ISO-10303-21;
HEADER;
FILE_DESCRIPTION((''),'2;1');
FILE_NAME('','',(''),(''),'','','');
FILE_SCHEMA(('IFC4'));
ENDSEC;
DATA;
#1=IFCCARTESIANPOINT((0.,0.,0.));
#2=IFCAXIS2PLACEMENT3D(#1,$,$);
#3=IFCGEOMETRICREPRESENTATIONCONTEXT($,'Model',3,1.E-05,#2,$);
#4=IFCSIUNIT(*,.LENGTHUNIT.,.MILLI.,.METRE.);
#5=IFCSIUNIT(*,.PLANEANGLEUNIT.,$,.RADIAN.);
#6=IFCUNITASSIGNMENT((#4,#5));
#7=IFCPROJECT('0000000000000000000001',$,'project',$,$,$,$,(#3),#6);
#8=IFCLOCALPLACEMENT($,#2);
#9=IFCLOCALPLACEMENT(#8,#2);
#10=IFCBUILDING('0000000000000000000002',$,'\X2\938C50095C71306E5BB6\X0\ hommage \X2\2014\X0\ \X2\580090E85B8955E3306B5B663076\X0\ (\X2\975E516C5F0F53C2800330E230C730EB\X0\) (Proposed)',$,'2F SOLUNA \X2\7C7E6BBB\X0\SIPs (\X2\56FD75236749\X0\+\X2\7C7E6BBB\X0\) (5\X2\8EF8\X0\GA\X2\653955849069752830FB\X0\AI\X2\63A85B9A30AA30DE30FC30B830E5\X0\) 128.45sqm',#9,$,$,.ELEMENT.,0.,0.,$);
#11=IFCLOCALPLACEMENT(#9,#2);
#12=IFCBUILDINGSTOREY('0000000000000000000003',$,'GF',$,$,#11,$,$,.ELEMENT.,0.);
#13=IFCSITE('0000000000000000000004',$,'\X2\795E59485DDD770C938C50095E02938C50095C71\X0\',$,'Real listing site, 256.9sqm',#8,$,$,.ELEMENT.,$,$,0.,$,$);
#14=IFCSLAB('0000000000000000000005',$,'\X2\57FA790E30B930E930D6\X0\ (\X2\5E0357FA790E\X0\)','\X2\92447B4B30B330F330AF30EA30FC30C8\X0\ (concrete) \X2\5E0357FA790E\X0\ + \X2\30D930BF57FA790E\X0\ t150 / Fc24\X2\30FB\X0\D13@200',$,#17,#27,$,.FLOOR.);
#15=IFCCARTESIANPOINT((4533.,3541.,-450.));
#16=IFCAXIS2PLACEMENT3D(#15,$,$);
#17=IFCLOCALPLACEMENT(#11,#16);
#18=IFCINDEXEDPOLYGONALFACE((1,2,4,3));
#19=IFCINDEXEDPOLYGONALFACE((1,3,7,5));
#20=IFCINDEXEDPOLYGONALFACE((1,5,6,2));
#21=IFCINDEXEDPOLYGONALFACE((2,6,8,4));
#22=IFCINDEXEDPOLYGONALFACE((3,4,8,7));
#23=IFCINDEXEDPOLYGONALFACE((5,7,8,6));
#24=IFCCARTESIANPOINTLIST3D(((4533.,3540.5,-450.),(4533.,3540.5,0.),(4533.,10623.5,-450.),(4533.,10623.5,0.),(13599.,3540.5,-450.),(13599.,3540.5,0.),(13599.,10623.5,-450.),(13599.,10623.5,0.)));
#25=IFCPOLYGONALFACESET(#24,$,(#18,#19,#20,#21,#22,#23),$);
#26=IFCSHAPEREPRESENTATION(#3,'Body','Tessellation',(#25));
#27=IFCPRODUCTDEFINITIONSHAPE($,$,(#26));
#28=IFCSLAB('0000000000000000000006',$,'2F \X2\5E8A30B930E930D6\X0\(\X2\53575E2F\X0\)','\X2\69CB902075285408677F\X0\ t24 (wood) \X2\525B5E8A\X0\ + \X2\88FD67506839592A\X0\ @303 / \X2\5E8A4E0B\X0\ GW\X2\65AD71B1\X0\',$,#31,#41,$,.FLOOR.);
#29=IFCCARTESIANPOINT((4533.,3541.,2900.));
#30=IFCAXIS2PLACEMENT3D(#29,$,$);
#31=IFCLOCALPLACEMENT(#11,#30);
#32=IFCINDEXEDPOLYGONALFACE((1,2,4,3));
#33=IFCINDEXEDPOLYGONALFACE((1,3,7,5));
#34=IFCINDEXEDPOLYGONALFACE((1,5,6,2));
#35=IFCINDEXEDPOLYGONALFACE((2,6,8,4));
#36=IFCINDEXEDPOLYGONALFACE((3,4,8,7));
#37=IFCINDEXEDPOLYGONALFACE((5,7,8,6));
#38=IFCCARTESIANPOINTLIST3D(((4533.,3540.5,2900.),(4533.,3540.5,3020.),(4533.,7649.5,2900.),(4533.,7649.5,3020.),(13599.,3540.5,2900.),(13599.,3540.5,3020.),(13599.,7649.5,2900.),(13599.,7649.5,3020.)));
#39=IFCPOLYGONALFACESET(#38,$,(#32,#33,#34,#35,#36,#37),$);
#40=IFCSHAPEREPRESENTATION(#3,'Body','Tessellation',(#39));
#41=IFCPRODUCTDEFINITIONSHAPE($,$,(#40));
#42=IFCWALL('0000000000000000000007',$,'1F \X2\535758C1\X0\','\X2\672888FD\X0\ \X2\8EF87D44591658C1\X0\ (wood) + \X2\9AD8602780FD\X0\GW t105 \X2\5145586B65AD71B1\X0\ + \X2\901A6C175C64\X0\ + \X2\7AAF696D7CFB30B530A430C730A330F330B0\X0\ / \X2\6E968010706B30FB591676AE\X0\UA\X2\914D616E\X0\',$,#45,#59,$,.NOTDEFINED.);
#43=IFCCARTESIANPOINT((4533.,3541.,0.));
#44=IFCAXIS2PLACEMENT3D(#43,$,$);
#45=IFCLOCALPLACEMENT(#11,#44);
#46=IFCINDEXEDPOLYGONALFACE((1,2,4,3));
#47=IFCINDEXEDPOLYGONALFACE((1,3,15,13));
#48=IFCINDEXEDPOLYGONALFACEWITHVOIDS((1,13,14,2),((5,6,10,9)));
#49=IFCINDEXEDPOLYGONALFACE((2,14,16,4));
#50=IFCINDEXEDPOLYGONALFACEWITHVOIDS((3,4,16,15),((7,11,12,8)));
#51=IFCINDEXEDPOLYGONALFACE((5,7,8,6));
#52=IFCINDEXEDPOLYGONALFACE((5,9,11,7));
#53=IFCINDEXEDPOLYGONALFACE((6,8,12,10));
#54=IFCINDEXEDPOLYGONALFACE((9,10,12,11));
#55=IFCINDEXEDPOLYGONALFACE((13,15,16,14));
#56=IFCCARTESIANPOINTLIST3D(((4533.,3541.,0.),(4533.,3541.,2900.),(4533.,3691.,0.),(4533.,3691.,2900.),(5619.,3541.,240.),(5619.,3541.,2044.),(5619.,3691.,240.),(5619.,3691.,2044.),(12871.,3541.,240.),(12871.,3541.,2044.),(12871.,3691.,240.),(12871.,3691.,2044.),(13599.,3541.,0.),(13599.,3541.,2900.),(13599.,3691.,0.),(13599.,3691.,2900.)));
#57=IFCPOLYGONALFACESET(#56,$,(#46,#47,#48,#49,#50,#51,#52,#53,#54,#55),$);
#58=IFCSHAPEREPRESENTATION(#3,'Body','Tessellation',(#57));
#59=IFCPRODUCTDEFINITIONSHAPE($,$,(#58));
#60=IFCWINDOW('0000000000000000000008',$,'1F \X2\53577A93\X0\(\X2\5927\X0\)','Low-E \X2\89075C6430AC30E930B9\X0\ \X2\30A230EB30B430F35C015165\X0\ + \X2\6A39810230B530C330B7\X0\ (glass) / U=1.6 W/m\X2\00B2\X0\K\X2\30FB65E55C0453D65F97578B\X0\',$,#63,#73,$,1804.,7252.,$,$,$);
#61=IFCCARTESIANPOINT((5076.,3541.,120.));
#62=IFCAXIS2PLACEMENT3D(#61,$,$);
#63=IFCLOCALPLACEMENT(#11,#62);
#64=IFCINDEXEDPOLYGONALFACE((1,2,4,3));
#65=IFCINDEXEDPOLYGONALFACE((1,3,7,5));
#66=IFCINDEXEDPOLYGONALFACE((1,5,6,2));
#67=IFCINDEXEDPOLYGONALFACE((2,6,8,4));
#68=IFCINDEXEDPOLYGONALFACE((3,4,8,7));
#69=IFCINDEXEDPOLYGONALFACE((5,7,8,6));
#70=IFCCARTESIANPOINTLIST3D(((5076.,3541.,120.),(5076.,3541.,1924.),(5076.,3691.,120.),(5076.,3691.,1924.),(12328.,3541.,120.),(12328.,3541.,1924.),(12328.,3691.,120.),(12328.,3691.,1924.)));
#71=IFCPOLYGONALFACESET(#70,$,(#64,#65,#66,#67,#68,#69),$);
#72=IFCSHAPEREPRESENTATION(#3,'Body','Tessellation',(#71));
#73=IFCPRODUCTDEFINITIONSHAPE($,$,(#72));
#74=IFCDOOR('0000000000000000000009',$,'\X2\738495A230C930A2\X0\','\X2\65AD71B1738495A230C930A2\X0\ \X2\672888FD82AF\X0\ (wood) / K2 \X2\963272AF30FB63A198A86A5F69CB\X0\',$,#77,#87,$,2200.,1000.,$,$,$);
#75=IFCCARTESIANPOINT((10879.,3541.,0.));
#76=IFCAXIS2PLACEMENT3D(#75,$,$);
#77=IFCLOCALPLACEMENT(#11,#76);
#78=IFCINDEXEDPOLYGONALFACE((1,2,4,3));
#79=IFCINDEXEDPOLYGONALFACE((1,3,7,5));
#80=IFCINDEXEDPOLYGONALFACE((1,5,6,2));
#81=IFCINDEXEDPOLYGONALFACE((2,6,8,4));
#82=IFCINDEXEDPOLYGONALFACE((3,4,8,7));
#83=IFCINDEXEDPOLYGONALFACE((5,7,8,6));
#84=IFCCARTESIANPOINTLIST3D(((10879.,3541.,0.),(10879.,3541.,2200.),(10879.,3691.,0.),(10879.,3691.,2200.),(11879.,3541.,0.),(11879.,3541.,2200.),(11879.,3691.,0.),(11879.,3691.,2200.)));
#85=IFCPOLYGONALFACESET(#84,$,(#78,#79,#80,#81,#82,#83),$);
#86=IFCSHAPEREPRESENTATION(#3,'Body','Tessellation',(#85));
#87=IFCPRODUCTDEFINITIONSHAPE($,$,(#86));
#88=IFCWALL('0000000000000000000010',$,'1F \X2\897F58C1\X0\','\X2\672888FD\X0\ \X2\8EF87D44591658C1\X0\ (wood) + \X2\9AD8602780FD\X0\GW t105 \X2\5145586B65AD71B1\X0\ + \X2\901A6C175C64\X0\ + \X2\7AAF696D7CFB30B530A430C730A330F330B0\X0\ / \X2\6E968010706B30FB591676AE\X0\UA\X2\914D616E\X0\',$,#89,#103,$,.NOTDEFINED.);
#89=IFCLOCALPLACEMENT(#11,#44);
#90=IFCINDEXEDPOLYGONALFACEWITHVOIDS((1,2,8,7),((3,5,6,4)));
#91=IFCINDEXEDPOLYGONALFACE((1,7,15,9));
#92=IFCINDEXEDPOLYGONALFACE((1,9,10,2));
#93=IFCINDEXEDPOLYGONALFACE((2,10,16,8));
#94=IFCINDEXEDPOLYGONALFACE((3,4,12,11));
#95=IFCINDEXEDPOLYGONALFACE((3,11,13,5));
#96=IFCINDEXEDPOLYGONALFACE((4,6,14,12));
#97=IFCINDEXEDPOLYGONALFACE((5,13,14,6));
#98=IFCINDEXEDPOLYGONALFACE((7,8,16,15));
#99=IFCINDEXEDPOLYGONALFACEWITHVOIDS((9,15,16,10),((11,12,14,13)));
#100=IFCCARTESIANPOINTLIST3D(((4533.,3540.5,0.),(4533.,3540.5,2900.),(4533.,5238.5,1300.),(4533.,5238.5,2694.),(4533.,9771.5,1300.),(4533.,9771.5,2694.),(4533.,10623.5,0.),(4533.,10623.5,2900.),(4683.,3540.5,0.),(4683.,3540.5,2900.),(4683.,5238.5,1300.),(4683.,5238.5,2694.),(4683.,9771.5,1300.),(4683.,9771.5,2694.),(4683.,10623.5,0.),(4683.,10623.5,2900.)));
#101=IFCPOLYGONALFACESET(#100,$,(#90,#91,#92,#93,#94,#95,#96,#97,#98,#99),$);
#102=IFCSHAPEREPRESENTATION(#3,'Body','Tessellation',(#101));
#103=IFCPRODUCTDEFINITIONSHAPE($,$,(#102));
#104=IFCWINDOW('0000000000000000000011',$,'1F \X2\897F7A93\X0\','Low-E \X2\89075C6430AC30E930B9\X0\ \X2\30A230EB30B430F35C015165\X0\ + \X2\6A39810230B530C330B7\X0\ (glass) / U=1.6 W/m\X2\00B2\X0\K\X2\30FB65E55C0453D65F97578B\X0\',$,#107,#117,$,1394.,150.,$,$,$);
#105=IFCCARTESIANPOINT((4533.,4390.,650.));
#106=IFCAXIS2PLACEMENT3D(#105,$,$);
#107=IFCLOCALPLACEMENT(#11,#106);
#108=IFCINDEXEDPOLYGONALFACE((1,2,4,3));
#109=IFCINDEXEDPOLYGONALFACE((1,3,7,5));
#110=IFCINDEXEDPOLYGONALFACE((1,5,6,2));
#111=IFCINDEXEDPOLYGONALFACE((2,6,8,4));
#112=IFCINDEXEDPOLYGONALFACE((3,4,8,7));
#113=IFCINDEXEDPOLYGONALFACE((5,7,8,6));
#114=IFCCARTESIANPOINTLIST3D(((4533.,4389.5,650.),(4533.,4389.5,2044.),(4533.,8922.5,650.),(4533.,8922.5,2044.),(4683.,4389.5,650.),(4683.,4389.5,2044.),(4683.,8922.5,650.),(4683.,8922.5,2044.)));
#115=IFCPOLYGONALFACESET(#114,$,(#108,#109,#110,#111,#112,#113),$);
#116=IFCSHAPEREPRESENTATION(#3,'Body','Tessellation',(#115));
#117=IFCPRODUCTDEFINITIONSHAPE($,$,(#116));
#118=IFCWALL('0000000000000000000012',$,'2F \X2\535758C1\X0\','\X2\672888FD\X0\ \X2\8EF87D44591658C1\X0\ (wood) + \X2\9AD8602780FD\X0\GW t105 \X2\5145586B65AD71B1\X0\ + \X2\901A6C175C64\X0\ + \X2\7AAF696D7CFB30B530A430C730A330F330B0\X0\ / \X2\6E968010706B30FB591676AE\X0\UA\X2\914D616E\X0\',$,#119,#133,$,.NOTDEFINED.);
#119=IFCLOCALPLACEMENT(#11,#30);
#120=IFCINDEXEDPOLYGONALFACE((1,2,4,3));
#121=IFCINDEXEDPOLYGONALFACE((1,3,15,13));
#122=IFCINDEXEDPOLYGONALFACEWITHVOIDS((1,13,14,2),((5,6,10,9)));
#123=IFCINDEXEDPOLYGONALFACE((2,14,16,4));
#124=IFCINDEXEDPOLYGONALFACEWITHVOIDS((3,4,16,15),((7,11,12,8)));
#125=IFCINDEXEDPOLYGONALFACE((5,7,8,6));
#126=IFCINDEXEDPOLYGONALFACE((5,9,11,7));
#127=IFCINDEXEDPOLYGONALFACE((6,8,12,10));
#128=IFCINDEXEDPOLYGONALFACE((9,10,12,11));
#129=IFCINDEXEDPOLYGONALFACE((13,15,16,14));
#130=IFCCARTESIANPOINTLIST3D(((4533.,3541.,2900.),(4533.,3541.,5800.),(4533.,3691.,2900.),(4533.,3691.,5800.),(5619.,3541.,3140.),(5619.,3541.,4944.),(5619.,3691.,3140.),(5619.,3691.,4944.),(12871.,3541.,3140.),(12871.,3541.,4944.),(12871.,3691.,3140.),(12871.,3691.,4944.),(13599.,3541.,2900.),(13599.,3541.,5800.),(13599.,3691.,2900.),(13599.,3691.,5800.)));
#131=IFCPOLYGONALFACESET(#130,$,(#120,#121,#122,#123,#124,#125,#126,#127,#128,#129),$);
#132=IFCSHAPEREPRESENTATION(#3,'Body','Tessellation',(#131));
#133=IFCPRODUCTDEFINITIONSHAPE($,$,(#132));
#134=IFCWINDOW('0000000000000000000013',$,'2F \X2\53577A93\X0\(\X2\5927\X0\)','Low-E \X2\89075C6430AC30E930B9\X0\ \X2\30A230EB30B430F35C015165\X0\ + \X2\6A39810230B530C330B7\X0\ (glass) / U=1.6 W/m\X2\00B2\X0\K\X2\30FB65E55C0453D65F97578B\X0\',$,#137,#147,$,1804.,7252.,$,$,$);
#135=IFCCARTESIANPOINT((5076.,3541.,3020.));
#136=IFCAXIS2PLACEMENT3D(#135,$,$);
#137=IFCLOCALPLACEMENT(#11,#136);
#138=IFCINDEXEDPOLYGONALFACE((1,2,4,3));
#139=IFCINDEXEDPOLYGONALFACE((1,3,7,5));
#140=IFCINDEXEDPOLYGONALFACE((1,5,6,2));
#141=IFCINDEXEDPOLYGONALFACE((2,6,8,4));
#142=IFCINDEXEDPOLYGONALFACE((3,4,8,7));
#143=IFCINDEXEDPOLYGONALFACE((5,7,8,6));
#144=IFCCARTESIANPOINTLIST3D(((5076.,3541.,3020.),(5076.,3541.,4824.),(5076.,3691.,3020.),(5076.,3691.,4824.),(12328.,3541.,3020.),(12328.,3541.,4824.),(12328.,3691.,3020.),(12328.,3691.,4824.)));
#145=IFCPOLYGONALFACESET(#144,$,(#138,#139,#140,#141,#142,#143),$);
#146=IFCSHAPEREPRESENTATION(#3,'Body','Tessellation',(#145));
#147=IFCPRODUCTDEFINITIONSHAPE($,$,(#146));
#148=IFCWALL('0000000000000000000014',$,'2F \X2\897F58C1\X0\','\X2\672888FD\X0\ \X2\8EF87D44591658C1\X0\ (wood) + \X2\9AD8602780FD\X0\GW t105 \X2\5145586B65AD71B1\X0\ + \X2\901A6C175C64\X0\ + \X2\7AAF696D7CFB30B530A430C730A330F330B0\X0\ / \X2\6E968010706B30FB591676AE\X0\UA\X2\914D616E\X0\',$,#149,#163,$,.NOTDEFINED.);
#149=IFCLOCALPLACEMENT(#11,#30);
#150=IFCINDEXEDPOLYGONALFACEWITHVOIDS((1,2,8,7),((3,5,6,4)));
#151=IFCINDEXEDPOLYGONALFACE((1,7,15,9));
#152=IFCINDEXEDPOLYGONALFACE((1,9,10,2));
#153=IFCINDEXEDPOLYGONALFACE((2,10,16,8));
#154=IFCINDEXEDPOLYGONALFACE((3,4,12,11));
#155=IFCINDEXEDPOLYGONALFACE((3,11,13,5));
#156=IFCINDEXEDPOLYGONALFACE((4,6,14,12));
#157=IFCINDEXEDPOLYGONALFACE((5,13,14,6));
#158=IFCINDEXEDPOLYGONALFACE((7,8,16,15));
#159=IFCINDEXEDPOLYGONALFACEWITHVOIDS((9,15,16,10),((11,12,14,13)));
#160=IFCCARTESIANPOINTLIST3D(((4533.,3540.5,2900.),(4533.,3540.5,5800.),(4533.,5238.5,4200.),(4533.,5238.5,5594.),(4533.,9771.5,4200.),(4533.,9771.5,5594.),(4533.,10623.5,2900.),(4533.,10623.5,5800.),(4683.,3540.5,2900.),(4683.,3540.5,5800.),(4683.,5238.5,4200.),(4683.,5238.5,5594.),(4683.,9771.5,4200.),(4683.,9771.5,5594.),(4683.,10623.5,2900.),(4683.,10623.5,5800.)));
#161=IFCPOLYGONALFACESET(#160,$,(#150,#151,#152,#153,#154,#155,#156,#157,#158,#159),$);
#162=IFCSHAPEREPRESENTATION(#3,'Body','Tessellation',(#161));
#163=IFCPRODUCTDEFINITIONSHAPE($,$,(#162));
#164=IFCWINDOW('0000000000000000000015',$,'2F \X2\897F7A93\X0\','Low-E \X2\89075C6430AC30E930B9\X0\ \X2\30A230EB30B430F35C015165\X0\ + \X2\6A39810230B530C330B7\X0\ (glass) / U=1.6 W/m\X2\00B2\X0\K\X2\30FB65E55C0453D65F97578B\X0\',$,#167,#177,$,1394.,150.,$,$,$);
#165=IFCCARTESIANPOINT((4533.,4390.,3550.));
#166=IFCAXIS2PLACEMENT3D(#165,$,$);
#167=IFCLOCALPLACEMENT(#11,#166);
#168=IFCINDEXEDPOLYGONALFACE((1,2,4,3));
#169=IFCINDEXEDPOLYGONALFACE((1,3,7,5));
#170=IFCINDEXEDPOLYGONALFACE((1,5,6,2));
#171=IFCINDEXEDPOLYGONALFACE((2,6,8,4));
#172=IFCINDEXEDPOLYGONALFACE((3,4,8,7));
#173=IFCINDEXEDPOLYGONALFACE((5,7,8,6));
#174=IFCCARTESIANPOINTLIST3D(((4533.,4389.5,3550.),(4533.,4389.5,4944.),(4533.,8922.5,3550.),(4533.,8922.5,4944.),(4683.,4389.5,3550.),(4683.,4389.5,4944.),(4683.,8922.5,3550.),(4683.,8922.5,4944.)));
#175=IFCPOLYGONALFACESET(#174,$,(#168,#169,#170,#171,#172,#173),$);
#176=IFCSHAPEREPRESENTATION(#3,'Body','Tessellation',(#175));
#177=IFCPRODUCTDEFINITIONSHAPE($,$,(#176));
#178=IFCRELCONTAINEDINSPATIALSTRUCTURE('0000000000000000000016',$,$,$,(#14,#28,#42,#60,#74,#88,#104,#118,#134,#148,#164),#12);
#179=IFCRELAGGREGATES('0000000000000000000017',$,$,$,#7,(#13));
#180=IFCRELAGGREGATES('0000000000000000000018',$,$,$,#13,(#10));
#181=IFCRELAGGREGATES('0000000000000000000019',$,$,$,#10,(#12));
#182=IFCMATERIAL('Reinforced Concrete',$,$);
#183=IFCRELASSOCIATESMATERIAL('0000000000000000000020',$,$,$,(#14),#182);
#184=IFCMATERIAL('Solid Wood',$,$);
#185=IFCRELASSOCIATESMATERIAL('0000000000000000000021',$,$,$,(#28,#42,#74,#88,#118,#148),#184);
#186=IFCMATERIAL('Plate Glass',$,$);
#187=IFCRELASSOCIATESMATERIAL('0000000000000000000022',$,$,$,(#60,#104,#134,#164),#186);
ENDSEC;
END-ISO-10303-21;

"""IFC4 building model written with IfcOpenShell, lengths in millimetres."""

from ifc_helpers import new_model, si_unit, frame, frame_2d, origin, place, context, project, spatial, rectangle, extrude, material, element, fill, save


model = new_model("IFC4")

# Units and contexts
model_context = context("Model", 3, precision=1e-05, world=origin())
ifc_project = project(units=[si_unit("LENGTHUNIT", "METRE", prefix="MILLI"), si_unit("PLANEANGLEUNIT", "RADIAN")], contexts=[model_context])

# Site, building, storey
site_placement = place(None, origin())
site = spatial("IfcSite", under=ifc_project, at=site_placement, Name="神奈川県鎌倉市鎌倉山", ObjectType="Real listing site, 256.9sqm", CompositionType="ELEMENT", RefElevation=0.0)
building_placement = place(site_placement, origin())
building = spatial("IfcBuilding", under=site, at=building_placement, Name="鎌倉山の家 hommage — 堀部安嗣に学ぶ (非公式参考モデル) (Proposed)", ObjectType="2F SOLUNA 籾殻SIPs (国産杉+籾殻) (5軸GA改善適用・AI推定オマージュ) 128.45sqm", CompositionType="ELEMENT", ElevationOfRefHeight=0.0, ElevationOfTerrain=0.0)
storey_placement = place(building_placement, origin())
storey = spatial("IfcBuildingStorey", under=building, at=storey_placement, Name="GF", CompositionType="ELEMENT", Elevation=0.0)

# Slabs
ifc_material_1 = material(Name="Reinforced Concrete")
slab_1_placement = place(storey_placement, frame((4533.0, 3541.0, -450.0)))
element("IfcSlab", 1, at=slab_1_placement, inside=storey, material=ifc_material_1, Name="基礎スラブ (布基礎)", Description="鉄筋コンクリート (concrete) 布基礎 + ベタ基礎 t150 / Fc24・D13@200", PredefinedType="FLOOR", context=model_context, shape_type="SweptSolid", body=[
    extrude(rectangle(XDim=9066.0, YDim=7083.0, at=frame_2d((4533.0, 3541.0))), frame((4533.0, 3541.0, -450.0)), (0.0, 0.0, 1.0), 450.0),
])
ifc_material_2 = material(Name="Solid Wood")
slab_2_placement = place(storey_placement, frame((4533.0, 3541.0, 2900.0)))
element("IfcSlab", 2, at=slab_2_placement, inside=storey, material=ifc_material_2, Name="2F 床スラブ(南帯)", Description="構造用合板 t24 (wood) 剛床 + 製材根太 @303 / 床下 GW断熱", PredefinedType="FLOOR", context=model_context, shape_type="SweptSolid", body=[
    extrude(rectangle(XDim=9066.0, YDim=4109.0, at=frame_2d((4533.0, 2054.0))), frame((4533.0, 3541.0, 2900.0)), (0.0, 0.0, 1.0), 120.0),
])

# Wall, openings, window, door
wall_1_placement = place(storey_placement, frame((4533.0, 3541.0, 0.0)))
wall_1 = element("IfcWall", 3, at=wall_1_placement, inside=storey, material=ifc_material_2, Name="1F 南壁", Description="木製 軸組外壁 (wood) + 高性能GW t105 充填断熱 + 通気層 + 窯業系サイディング / 準耐火・外皮UA配慮", PredefinedType="NOTDEFINED", context=model_context, shape_type="SweptSolid", body=[
    extrude(rectangle(XDim=9066.0, YDim=150.0, at=frame_2d((4533.0, 75.0))), frame((4533.0, 3541.0, 0.0)), (0.0, 0.0, 1.0), 2900.0),
])
opening_1_placement = place(storey_placement, frame((5076.0, 3541.0, 120.0)))
opening_1 = element("IfcOpeningElement", 4, at=opening_1_placement, cuts=wall_1, PredefinedType="NOTDEFINED", context=model_context, shape_type="SweptSolid", body=[
    extrude(rectangle(XDim=7252.0, YDim=150.0, at=frame_2d((3626.0, 75.0))), frame((5076.0, 3541.0, 120.0)), (0.0, 0.0, 1.0), 1804.0),
])
opening_2_placement = place(storey_placement, frame((10879.0, 3541.0, 0.0)))
opening_2 = element("IfcOpeningElement", 5, at=opening_2_placement, cuts=wall_1, PredefinedType="NOTDEFINED", context=model_context, shape_type="SweptSolid", body=[
    extrude(rectangle(XDim=1000.0, YDim=150.0, at=frame_2d((500.0, 75.0))), frame((10879.0, 3541.0, 0.0)), (0.0, 0.0, 1.0), 2200.0),
])
ifc_material_3 = material(Name="Plate Glass")
window_1_placement = place(storey_placement, frame((5076.0, 3541.0, 120.0)))
window_1 = element("IfcWindow", 6, at=window_1_placement, inside=storey, material=ifc_material_3, Name="1F 南窓(大)", Description="Low-E 複層ガラス アルゴン封入 + 樹脂サッシ (glass) / U=1.6 W/m²K・日射取得型", OverallHeight=1804.0, OverallWidth=7252.0, context=model_context, shape_type="SweptSolid", body=[
    extrude(rectangle(XDim=7252.0, YDim=150.0, at=frame_2d((3626.0, 75.0))), frame((5076.0, 3541.0, 120.0)), (0.0, 0.0, 1.0), 1804.0),
])
fill(opening_1, window_1)
door_placement = place(storey_placement, frame((10879.0, 3541.0, 0.0)))
door = element("IfcDoor", 7, at=door_placement, inside=storey, material=ifc_material_2, Name="玄関ドア", Description="断熱玄関ドア 木製芯 (wood) / K2 防犯・採風機構", OverallHeight=2200.0, OverallWidth=1000.0, context=model_context, shape_type="SweptSolid", body=[
    extrude(rectangle(XDim=1000.0, YDim=150.0, at=frame_2d((500.0, 75.0))), frame((10879.0, 3541.0, 0.0)), (0.0, 0.0, 1.0), 2200.0),
])
fill(opening_2, door)

# Wall, opening, window
wall_2_placement = place(storey_placement, frame((4533.0, 3541.0, 0.0)))
wall_2 = element("IfcWall", 8, at=wall_2_placement, inside=storey, material=ifc_material_2, Name="1F 西壁", Description="木製 軸組外壁 (wood) + 高性能GW t105 充填断熱 + 通気層 + 窯業系サイディング / 準耐火・外皮UA配慮", PredefinedType="NOTDEFINED", context=model_context, shape_type="SweptSolid", body=[
    extrude(rectangle(XDim=150.0, YDim=7083.0, at=frame_2d((75.0, 3541.0))), frame((4533.0, 3541.0, 0.0)), (0.0, 0.0, 1.0), 2900.0),
])
opening_3_placement = place(storey_placement, frame((4533.0, 4390.0, 650.0)))
opening_3 = element("IfcOpeningElement", 9, at=opening_3_placement, cuts=wall_2, PredefinedType="NOTDEFINED", context=model_context, shape_type="SweptSolid", body=[
    extrude(rectangle(XDim=150.0, YDim=4533.0, at=frame_2d((75.0, 2266.0))), frame((4533.0, 4390.0, 650.0)), (0.0, 0.0, 1.0), 1394.0),
])
window_2_placement = place(storey_placement, frame((4533.0, 4390.0, 650.0)))
window_2 = element("IfcWindow", 10, at=window_2_placement, inside=storey, material=ifc_material_3, Name="1F 西窓", Description="Low-E 複層ガラス アルゴン封入 + 樹脂サッシ (glass) / U=1.6 W/m²K・日射取得型", OverallHeight=1394.0, OverallWidth=150.0, context=model_context, shape_type="SweptSolid", body=[
    extrude(rectangle(XDim=150.0, YDim=4533.0, at=frame_2d((75.0, 2266.0))), frame((4533.0, 4390.0, 650.0)), (0.0, 0.0, 1.0), 1394.0),
])
fill(opening_3, window_2)

# Walls, openings, windows
wall_3_placement = place(storey_placement, frame((4533.0, 3541.0, 2900.0)))
wall_3 = element("IfcWall", 11, at=wall_3_placement, inside=storey, material=ifc_material_2, Name="2F 南壁", Description="木製 軸組外壁 (wood) + 高性能GW t105 充填断熱 + 通気層 + 窯業系サイディング / 準耐火・外皮UA配慮", PredefinedType="NOTDEFINED", context=model_context, shape_type="SweptSolid", body=[
    extrude(rectangle(XDim=9066.0, YDim=150.0, at=frame_2d((4533.0, 75.0))), frame((4533.0, 3541.0, 2900.0)), (0.0, 0.0, 1.0), 2900.0),
])
opening_4_placement = place(storey_placement, frame((5076.0, 3541.0, 3020.0)))
opening_4 = element("IfcOpeningElement", 12, at=opening_4_placement, cuts=wall_3, PredefinedType="NOTDEFINED", context=model_context, shape_type="SweptSolid", body=[
    extrude(rectangle(XDim=7252.0, YDim=150.0, at=frame_2d((3626.0, 75.0))), frame((5076.0, 3541.0, 3020.0)), (0.0, 0.0, 1.0), 1804.0),
])
window_3_placement = place(storey_placement, frame((5076.0, 3541.0, 3020.0)))
window_3 = element("IfcWindow", 13, at=window_3_placement, inside=storey, material=ifc_material_3, Name="2F 南窓(大)", Description="Low-E 複層ガラス アルゴン封入 + 樹脂サッシ (glass) / U=1.6 W/m²K・日射取得型", OverallHeight=1804.0, OverallWidth=7252.0, context=model_context, shape_type="SweptSolid", body=[
    extrude(rectangle(XDim=7252.0, YDim=150.0, at=frame_2d((3626.0, 75.0))), frame((5076.0, 3541.0, 3020.0)), (0.0, 0.0, 1.0), 1804.0),
])
fill(opening_4, window_3)
wall_4_placement = place(storey_placement, frame((4533.0, 3541.0, 2900.0)))
wall_4 = element("IfcWall", 14, at=wall_4_placement, inside=storey, material=ifc_material_2, Name="2F 西壁", Description="木製 軸組外壁 (wood) + 高性能GW t105 充填断熱 + 通気層 + 窯業系サイディング / 準耐火・外皮UA配慮", PredefinedType="NOTDEFINED", context=model_context, shape_type="SweptSolid", body=[
    extrude(rectangle(XDim=150.0, YDim=7083.0, at=frame_2d((75.0, 3541.0))), frame((4533.0, 3541.0, 2900.0)), (0.0, 0.0, 1.0), 2900.0),
])
opening_5_placement = place(storey_placement, frame((4533.0, 4390.0, 3550.0)))
opening_5 = element("IfcOpeningElement", 15, at=opening_5_placement, cuts=wall_4, PredefinedType="NOTDEFINED", context=model_context, shape_type="SweptSolid", body=[
    extrude(rectangle(XDim=150.0, YDim=4533.0, at=frame_2d((75.0, 2266.0))), frame((4533.0, 4390.0, 3550.0)), (0.0, 0.0, 1.0), 1394.0),
])
window_4_placement = place(storey_placement, frame((4533.0, 4390.0, 3550.0)))
window_4 = element("IfcWindow", 16, at=window_4_placement, inside=storey, material=ifc_material_3, Name="2F 西窓", Description="Low-E 複層ガラス アルゴン封入 + 樹脂サッシ (glass) / U=1.6 W/m²K・日射取得型", OverallHeight=1394.0, OverallWidth=150.0, context=model_context, shape_type="SweptSolid", body=[
    extrude(rectangle(XDim=150.0, YDim=4533.0, at=frame_2d((75.0, 2266.0))), frame((4533.0, 4390.0, 3550.0)), (0.0, 0.0, 1.0), 1394.0),
])
fill(opening_5, window_4)

save(model, "model.ifc")
